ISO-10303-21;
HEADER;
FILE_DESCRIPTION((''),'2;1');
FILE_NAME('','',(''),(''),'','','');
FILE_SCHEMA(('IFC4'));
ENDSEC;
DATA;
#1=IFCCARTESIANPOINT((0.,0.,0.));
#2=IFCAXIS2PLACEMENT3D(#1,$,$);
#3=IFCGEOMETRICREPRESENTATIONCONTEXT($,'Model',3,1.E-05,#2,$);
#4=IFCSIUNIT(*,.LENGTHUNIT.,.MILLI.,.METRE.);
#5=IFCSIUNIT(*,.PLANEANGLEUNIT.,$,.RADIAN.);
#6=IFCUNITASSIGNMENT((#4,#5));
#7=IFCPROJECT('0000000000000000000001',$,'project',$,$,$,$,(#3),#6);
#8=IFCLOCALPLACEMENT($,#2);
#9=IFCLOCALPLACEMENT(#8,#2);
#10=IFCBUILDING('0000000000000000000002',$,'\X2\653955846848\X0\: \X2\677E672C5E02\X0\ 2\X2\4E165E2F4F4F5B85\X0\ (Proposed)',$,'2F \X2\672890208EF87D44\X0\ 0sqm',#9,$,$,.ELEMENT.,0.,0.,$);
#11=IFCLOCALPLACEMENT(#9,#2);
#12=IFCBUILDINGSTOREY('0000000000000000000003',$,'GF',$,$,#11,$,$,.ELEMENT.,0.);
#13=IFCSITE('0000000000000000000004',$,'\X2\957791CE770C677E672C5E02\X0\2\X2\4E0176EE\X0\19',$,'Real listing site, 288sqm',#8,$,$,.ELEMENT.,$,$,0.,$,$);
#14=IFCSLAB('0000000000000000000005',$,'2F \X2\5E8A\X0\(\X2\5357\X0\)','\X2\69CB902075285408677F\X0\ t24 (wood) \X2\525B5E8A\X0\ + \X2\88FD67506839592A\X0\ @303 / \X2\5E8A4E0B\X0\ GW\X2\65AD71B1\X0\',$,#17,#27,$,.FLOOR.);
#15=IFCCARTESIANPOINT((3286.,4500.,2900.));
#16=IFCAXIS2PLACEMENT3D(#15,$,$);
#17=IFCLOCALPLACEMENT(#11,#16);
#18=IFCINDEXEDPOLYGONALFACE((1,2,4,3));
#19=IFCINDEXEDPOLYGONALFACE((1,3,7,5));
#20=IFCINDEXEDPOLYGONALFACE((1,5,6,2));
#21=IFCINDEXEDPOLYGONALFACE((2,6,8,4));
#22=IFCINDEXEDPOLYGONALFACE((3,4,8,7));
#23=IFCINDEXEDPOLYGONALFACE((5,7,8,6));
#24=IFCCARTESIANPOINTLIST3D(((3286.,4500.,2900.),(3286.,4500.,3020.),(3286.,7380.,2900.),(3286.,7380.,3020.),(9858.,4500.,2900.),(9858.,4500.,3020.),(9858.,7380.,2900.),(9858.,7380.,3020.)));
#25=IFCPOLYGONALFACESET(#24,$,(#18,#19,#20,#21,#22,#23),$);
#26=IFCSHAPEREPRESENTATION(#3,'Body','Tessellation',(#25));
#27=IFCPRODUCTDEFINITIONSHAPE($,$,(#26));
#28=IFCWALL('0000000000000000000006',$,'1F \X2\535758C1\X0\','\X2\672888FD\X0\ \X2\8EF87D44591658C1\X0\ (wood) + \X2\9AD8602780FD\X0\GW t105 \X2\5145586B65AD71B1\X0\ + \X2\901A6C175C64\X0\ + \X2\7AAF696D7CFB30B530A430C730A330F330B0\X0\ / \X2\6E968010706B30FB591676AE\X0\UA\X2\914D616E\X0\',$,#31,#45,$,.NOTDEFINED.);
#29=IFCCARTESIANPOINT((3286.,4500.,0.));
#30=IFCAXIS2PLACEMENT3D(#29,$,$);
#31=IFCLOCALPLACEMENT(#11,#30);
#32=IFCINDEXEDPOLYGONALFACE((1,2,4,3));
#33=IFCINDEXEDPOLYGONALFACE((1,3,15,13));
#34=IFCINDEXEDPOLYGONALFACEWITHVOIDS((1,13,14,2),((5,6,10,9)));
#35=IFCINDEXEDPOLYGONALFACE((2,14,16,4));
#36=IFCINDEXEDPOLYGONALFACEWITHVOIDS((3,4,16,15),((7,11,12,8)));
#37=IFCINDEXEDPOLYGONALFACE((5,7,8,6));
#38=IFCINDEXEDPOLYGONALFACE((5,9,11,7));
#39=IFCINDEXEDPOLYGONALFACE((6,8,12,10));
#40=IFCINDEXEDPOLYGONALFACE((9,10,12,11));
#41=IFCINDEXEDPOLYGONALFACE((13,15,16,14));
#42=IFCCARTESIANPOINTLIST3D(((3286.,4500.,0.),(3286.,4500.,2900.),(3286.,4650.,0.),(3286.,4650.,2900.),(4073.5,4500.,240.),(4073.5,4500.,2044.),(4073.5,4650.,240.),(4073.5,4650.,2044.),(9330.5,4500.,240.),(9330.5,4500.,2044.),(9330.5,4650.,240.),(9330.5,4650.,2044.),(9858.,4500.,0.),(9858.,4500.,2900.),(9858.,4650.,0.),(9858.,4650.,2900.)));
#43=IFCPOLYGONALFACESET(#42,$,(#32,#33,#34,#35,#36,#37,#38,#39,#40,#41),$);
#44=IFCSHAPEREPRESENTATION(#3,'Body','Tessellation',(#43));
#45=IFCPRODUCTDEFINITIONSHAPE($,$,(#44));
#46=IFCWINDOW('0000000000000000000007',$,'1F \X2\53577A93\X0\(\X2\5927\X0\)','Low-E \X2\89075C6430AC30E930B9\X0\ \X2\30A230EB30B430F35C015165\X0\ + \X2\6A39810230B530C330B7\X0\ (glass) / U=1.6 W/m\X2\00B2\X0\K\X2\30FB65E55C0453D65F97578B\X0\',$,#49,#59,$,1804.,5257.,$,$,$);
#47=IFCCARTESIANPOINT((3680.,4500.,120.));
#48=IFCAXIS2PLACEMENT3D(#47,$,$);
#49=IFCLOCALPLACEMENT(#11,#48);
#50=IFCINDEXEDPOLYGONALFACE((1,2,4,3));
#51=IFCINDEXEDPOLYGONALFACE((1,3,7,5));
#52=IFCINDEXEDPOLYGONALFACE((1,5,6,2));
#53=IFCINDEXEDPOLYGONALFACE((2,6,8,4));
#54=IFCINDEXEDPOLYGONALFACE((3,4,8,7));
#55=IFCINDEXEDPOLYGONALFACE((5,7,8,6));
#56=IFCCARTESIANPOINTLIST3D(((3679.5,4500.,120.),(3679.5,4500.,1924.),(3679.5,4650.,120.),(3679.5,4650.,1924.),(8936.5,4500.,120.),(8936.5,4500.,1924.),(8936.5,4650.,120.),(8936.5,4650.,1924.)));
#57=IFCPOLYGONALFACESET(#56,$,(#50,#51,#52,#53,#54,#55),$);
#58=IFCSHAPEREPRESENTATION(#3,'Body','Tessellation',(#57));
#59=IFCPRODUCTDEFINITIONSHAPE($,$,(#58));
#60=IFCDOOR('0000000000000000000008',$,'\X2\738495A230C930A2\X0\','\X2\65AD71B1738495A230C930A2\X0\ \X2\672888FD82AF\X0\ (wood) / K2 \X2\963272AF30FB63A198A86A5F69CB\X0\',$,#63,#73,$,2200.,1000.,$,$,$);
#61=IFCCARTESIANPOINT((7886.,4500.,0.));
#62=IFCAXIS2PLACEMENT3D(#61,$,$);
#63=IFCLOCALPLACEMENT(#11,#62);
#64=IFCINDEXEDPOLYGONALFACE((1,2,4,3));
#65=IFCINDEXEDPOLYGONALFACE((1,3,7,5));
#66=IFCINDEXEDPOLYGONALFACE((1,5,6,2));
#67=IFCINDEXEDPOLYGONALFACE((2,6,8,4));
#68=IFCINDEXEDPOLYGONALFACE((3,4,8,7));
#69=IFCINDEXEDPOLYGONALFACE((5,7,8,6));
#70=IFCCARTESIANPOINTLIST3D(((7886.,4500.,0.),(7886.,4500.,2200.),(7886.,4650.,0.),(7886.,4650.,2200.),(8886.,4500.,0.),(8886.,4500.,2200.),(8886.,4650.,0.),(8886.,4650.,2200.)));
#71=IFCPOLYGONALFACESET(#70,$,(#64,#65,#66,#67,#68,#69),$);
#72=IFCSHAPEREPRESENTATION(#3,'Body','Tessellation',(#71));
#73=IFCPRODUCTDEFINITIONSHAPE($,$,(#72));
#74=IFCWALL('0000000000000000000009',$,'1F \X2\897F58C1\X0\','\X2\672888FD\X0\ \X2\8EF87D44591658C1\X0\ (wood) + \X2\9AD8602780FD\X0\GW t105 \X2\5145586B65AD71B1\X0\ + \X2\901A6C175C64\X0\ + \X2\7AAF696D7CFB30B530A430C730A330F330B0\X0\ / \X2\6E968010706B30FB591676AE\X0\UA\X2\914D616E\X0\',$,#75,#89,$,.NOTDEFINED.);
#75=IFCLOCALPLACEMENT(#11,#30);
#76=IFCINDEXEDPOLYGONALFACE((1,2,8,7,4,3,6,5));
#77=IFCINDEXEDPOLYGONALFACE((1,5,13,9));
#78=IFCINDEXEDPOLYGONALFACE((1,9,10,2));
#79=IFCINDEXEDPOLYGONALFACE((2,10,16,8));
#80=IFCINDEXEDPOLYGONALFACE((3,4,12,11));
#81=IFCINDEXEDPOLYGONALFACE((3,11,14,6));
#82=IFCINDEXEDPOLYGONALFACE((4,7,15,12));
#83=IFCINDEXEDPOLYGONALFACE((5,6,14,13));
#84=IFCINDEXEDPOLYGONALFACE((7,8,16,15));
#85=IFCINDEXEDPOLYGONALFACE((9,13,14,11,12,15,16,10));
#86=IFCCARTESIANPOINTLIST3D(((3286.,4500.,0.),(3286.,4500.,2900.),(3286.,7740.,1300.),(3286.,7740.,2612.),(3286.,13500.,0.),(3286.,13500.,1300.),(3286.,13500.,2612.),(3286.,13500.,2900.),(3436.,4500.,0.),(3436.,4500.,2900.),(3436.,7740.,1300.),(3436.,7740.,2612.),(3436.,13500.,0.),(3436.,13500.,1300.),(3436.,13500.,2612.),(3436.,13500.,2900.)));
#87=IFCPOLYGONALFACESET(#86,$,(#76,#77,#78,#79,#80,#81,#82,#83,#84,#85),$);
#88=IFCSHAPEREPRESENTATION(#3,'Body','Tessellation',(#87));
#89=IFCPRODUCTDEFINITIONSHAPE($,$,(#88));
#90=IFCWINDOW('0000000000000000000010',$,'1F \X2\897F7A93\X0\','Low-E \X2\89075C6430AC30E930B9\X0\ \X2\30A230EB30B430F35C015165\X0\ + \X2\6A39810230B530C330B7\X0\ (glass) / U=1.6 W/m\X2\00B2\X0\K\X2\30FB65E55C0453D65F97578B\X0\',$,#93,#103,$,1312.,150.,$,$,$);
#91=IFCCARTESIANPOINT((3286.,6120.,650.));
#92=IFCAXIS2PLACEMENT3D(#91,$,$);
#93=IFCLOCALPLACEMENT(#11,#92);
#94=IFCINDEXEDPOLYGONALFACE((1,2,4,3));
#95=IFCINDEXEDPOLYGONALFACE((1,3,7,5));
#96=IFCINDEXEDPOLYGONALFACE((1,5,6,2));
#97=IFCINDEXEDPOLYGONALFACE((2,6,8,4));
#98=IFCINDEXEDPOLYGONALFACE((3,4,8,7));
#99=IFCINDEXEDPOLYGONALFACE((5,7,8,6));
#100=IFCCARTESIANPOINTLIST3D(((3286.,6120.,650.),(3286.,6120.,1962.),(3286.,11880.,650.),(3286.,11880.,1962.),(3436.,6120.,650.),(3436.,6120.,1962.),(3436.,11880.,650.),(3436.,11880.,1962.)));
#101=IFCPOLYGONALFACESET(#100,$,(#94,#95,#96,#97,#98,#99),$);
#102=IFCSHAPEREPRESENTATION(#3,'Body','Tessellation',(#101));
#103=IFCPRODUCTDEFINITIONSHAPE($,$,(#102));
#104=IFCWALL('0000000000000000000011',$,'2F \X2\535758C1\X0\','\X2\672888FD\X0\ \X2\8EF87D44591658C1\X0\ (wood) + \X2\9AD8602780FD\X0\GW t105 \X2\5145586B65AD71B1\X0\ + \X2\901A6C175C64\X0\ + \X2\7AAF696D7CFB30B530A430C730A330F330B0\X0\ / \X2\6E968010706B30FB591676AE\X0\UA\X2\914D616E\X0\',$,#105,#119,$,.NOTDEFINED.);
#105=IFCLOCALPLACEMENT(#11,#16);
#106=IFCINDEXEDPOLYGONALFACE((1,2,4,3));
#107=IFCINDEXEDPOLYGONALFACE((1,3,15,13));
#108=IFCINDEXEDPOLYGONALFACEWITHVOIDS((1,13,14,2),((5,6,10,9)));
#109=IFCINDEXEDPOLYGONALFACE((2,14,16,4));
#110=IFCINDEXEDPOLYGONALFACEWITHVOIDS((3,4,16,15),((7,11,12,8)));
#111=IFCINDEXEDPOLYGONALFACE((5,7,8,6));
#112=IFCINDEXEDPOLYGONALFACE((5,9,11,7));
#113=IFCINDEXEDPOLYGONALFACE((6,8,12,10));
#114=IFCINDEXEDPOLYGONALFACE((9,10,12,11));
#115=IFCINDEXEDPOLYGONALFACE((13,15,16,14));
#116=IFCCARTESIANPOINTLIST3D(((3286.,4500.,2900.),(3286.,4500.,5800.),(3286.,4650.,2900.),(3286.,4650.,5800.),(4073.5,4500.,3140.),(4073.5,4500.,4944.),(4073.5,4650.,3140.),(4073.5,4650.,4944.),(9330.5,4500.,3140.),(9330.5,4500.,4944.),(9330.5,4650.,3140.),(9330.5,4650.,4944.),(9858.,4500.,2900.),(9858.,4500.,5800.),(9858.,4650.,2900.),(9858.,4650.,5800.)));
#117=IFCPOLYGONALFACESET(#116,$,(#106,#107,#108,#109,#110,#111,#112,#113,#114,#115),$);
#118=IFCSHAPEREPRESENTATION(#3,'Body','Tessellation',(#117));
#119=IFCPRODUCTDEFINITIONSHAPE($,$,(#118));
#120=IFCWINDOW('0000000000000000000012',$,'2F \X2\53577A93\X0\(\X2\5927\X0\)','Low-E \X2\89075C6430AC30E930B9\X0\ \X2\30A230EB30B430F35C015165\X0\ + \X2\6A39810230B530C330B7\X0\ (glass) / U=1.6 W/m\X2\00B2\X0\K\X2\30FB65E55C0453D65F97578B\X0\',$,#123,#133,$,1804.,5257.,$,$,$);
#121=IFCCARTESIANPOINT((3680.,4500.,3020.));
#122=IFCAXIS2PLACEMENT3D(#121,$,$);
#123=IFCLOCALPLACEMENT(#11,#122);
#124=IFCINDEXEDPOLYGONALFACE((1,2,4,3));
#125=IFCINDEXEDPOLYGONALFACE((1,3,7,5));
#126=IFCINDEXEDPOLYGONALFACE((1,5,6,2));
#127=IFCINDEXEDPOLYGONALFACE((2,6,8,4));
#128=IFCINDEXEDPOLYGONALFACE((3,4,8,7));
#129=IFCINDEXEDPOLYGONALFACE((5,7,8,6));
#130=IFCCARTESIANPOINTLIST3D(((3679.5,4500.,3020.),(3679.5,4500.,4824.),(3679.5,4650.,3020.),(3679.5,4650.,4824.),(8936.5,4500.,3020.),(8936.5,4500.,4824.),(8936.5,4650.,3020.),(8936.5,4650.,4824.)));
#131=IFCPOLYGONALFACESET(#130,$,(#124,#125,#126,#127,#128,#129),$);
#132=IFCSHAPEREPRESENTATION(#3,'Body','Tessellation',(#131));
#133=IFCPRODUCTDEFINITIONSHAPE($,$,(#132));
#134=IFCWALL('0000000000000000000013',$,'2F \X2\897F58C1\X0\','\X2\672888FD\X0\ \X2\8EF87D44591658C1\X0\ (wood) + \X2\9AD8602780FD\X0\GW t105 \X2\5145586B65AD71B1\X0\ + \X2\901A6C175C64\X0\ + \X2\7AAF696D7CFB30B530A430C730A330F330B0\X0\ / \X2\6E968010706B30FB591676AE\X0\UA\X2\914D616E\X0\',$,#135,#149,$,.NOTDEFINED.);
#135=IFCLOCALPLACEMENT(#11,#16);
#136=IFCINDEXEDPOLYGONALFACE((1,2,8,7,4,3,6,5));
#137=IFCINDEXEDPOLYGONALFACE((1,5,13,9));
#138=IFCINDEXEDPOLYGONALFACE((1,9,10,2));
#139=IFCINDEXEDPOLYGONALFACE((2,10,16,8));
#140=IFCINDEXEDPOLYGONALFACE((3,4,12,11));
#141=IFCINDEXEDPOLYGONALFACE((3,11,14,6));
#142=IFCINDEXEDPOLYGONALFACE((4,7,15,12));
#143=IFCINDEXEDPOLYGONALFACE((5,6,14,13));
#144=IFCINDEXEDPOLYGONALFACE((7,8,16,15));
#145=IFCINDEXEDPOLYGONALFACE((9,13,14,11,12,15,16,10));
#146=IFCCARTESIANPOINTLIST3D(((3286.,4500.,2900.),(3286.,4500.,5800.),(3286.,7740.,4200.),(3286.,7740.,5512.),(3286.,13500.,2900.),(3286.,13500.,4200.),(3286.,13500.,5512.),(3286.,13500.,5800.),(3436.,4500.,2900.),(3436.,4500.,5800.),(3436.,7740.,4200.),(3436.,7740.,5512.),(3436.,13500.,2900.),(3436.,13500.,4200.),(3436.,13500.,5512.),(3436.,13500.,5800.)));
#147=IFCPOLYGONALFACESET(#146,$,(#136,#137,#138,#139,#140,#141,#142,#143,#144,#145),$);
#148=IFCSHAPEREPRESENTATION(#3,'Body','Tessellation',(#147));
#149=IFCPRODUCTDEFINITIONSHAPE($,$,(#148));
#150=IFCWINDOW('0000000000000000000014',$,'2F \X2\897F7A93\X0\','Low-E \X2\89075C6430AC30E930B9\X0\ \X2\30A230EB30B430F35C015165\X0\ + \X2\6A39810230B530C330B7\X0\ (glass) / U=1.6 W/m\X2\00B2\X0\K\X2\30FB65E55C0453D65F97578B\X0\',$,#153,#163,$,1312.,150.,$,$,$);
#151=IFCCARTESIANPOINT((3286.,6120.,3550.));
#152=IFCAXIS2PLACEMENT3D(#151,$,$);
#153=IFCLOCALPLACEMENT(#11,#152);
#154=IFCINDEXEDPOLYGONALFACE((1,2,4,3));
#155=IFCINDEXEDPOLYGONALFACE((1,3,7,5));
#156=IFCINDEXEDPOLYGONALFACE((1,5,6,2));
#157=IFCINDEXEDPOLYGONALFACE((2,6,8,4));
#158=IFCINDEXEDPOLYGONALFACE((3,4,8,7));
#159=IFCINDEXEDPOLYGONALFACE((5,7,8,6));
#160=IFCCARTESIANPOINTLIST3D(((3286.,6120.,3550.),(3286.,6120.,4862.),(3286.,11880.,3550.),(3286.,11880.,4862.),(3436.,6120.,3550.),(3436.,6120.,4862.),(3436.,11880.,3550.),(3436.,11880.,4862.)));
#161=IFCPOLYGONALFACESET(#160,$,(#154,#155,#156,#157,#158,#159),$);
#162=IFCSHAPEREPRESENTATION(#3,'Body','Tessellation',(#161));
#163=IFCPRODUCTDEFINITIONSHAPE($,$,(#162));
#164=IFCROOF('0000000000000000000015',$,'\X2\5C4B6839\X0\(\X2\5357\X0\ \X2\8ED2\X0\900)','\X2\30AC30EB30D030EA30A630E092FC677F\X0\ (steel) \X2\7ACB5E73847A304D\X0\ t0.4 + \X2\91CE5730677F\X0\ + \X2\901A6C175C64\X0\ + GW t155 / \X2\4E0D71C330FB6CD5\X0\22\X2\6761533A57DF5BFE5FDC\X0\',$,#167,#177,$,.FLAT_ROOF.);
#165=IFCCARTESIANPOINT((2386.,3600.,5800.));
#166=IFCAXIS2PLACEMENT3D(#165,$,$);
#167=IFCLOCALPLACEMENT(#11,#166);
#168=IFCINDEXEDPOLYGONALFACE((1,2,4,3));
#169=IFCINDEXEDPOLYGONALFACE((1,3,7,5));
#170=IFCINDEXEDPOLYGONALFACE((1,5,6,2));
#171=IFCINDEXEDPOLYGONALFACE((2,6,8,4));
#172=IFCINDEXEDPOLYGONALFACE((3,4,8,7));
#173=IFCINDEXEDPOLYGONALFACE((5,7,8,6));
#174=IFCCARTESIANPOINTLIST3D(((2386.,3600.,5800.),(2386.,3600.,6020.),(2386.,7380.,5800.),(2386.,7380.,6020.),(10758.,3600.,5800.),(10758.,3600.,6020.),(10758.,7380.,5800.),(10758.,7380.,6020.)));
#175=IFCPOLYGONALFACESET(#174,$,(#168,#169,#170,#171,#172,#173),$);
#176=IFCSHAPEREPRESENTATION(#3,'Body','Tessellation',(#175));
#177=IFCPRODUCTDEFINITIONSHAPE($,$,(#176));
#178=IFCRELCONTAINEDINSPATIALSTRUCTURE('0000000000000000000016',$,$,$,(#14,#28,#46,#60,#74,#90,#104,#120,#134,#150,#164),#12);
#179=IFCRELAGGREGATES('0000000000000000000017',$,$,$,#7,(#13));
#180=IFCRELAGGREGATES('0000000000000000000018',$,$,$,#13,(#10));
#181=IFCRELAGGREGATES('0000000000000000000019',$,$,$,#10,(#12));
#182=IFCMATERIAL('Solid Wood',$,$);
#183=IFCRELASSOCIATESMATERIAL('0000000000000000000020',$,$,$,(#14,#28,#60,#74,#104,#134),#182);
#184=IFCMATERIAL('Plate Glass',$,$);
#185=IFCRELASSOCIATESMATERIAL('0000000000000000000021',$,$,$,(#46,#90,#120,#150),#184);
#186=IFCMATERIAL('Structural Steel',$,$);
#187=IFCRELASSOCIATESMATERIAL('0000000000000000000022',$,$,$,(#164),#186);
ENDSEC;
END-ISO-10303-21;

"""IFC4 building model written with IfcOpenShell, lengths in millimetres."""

from ifc_helpers import new_model, si_unit, frame, frame_2d, origin, place, context, project, spatial, rectangle, extrude, material, element, fill, save


model = new_model("IFC4")

# Units and contexts
model_context = context("Model", 3, precision=1e-05, world=origin())
ifc_project = project(units=[si_unit("LENGTHUNIT", "METRE", prefix="MILLI"), si_unit("PLANEANGLEUNIT", "RADIAN")], contexts=[model_context])

# Site, building, storey
site_placement = place(None, origin())
site = spatial("IfcSite", under=ifc_project, at=site_placement, Name="長野県松本市2丁目19", ObjectType="Real listing site, 288sqm", CompositionType="ELEMENT", RefElevation=0.0)
building_placement = place(site_placement, origin())
building = spatial("IfcBuilding", under=site, at=building_placement, Name="改善案: 松本市 2世帯住宅 (Proposed)", ObjectType="2F 木造軸組 0sqm", CompositionType="ELEMENT", ElevationOfRefHeight=0.0, ElevationOfTerrain=0.0)
storey_placement = place(building_placement, origin())
storey = spatial("IfcBuildingStorey", under=building, at=storey_placement, Name="GF", CompositionType="ELEMENT", Elevation=0.0)

# Slab
ifc_material_1 = material(Name="Solid Wood")
slab_1_placement = place(storey_placement, frame((3286.0, 4500.0, 2900.0)))
element("IfcSlab", 1, at=slab_1_placement, inside=storey, material=ifc_material_1, Name="2F 床(南)", Description="構造用合板 t24 (wood) 剛床 + 製材根太 @303 / 床下 GW断熱", PredefinedType="FLOOR", context=model_context, shape_type="SweptSolid", body=[
    extrude(rectangle(XDim=6572.0, YDim=2880.0, at=frame_2d((3286.0, 1440.0))), frame((3286.0, 4500.0, 2900.0)), (0.0, 0.0, 1.0), 120.0),
])

# Wall, openings, window, door
wall_1_placement = place(storey_placement, frame((3286.0, 4500.0, 0.0)))
wall_1 = element("IfcWall", 2, at=wall_1_placement, inside=storey, material=ifc_material_1, Name="1F 南壁", Description="木製 軸組外壁 (wood) + 高性能GW t105 充填断熱 + 通気層 + 窯業系サイディング / 準耐火・外皮UA配慮", PredefinedType="NOTDEFINED", context=model_context, shape_type="SweptSolid", body=[
    extrude(rectangle(XDim=6572.0, YDim=150.0, at=frame_2d((3286.0, 75.0))), frame((3286.0, 4500.0, 0.0)), (0.0, 0.0, 1.0), 2900.0),
])
opening_1_placement = place(storey_placement, frame((3680.0, 4500.0, 120.0)))
opening_1 = element("IfcOpeningElement", 3, at=opening_1_placement, cuts=wall_1, PredefinedType="NOTDEFINED", context=model_context, shape_type="SweptSolid", body=[
    extrude(rectangle(XDim=5257.0, YDim=150.0, at=frame_2d((2628.0, 75.0))), frame((3680.0, 4500.0, 120.0)), (0.0, 0.0, 1.0), 1804.0),
])
opening_2_placement = place(storey_placement, frame((7886.0, 4500.0, 0.0)))
opening_2 = element("IfcOpeningElement", 4, at=opening_2_placement, cuts=wall_1, PredefinedType="NOTDEFINED", context=model_context, shape_type="SweptSolid", body=[
    extrude(rectangle(XDim=1000.0, YDim=150.0, at=frame_2d((500.0, 75.0))), frame((7886.0, 4500.0, 0.0)), (0.0, 0.0, 1.0), 2200.0),
])
ifc_material_2 = material(Name="Plate Glass")
window_1_placement = place(storey_placement, frame((3680.0, 4500.0, 120.0)))
window_1 = element("IfcWindow", 5, at=window_1_placement, inside=storey, material=ifc_material_2, Name="1F 南窓(大)", Description="Low-E 複層ガラス アルゴン封入 + 樹脂サッシ (glass) / U=1.6 W/m²K・日射取得型", OverallHeight=1804.0, OverallWidth=5257.0, context=model_context, shape_type="SweptSolid", body=[
    extrude(rectangle(XDim=5257.0, YDim=150.0, at=frame_2d((2628.0, 75.0))), frame((3680.0, 4500.0, 120.0)), (0.0, 0.0, 1.0), 1804.0),
])
fill(opening_1, window_1)
door_placement = place(storey_placement, frame((7886.0, 4500.0, 0.0)))
door = element("IfcDoor", 6, at=door_placement, inside=storey, material=ifc_material_1, Name="玄関ドア", Description="断熱玄関ドア 木製芯 (wood) / K2 防犯・採風機構", OverallHeight=2200.0, OverallWidth=1000.0, context=model_context, shape_type="SweptSolid", body=[
    extrude(rectangle(XDim=1000.0, YDim=150.0, at=frame_2d((500.0, 75.0))), frame((7886.0, 4500.0, 0.0)), (0.0, 0.0, 1.0), 2200.0),
])
fill(opening_2, door)

# Walls, openings, windows
wall_2_placement = place(storey_placement, frame((3286.0, 4500.0, 0.0)))
wall_2 = element("IfcWall", 7, at=wall_2_placement, inside=storey, material=ifc_material_1, Name="1F 西壁", Description="木製 軸組外壁 (wood) + 高性能GW t105 充填断熱 + 通気層 + 窯業系サイディング / 準耐火・外皮UA配慮", PredefinedType="NOTDEFINED", context=model_context, shape_type="SweptSolid", body=[
    extrude(rectangle(XDim=150.0, YDim=9000.0, at=frame_2d((75.0, 4500.0))), frame((3286.0, 4500.0, 0.0)), (0.0, 0.0, 1.0), 2900.0),
])
opening_3_placement = place(storey_placement, frame((3286.0, 6120.0, 650.0)))
opening_3 = element("IfcOpeningElement", 8, at=opening_3_placement, cuts=wall_2, PredefinedType="NOTDEFINED", context=model_context, shape_type="SweptSolid", body=[
    extrude(rectangle(XDim=150.0, YDim=5760.0, at=frame_2d((75.0, 2880.0))), frame((3286.0, 6120.0, 650.0)), (0.0, 0.0, 1.0), 1312.0),
])
window_2_placement = place(storey_placement, frame((3286.0, 6120.0, 650.0)))
window_2 = element("IfcWindow", 9, at=window_2_placement, inside=storey, material=ifc_material_2, Name="1F 西窓", Description="Low-E 複層ガラス アルゴン封入 + 樹脂サッシ (glass) / U=1.6 W/m²K・日射取得型", OverallHeight=1312.0, OverallWidth=150.0, context=model_context, shape_type="SweptSolid", body=[
    extrude(rectangle(XDim=150.0, YDim=5760.0, at=frame_2d((75.0, 2880.0))), frame((3286.0, 6120.0, 650.0)), (0.0, 0.0, 1.0), 1312.0),
])
fill(opening_3, window_2)
wall_3_placement = place(storey_placement, frame((3286.0, 4500.0, 2900.0)))
wall_3 = element("IfcWall", 10, at=wall_3_placement, inside=storey, material=ifc_material_1, Name="2F 南壁", Description="木製 軸組外壁 (wood) + 高性能GW t105 充填断熱 + 通気層 + 窯業系サイディング / 準耐火・外皮UA配慮", PredefinedType="NOTDEFINED", context=model_context, shape_type="SweptSolid", body=[
    extrude(rectangle(XDim=6572.0, YDim=150.0, at=frame_2d((3286.0, 75.0))), frame((3286.0, 4500.0, 2900.0)), (0.0, 0.0, 1.0), 2900.0),
])
opening_4_placement = place(storey_placement, frame((3680.0, 4500.0, 3020.0)))
opening_4 = element("IfcOpeningElement", 11, at=opening_4_placement, cuts=wall_3, PredefinedType="NOTDEFINED", context=model_context, shape_type="SweptSolid", body=[
    extrude(rectangle(XDim=5257.0, YDim=150.0, at=frame_2d((2628.0, 75.0))), frame((3680.0, 4500.0, 3020.0)), (0.0, 0.0, 1.0), 1804.0),
])
window_3_placement = place(storey_placement, frame((3680.0, 4500.0, 3020.0)))
window_3 = element("IfcWindow", 12, at=window_3_placement, inside=storey, material=ifc_material_2, Name="2F 南窓(大)", Description="Low-E 複層ガラス アルゴン封入 + 樹脂サッシ (glass) / U=1.6 W/m²K・日射取得型", OverallHeight=1804.0, OverallWidth=5257.0, context=model_context, shape_type="SweptSolid", body=[
    extrude(rectangle(XDim=5257.0, YDim=150.0, at=frame_2d((2628.0, 75.0))), frame((3680.0, 4500.0, 3020.0)), (0.0, 0.0, 1.0), 1804.0),
])
fill(opening_4, window_3)
wall_4_placement = place(storey_placement, frame((3286.0, 4500.0, 2900.0)))
wall_4 = element("IfcWall", 13, at=wall_4_placement, inside=storey, material=ifc_material_1, Name="2F 西壁", Description="木製 軸組外壁 (wood) + 高性能GW t105 充填断熱 + 通気層 + 窯業系サイディング / 準耐火・外皮UA配慮", PredefinedType="NOTDEFINED", context=model_context, shape_type="SweptSolid", body=[
    extrude(rectangle(XDim=150.0, YDim=9000.0, at=frame_2d((75.0, 4500.0))), frame((3286.0, 4500.0, 2900.0)), (0.0, 0.0, 1.0), 2900.0),
])
opening_5_placement = place(storey_placement, frame((3286.0, 6120.0, 3550.0)))
opening_5 = element("IfcOpeningElement", 14, at=opening_5_placement, cuts=wall_4, PredefinedType="NOTDEFINED", context=model_context, shape_type="SweptSolid", body=[
    extrude(rectangle(XDim=150.0, YDim=5760.0, at=frame_2d((75.0, 2880.0))), frame((3286.0, 6120.0, 3550.0)), (0.0, 0.0, 1.0), 1312.0),
])
window_4_placement = place(storey_placement, frame((3286.0, 6120.0, 3550.0)))
window_4 = element("IfcWindow", 15, at=window_4_placement, inside=storey, material=ifc_material_2, Name="2F 西窓", Description="Low-E 複層ガラス アルゴン封入 + 樹脂サッシ (glass) / U=1.6 W/m²K・日射取得型", OverallHeight=1312.0, OverallWidth=150.0, context=model_context, shape_type="SweptSolid", body=[
    extrude(rectangle(XDim=150.0, YDim=5760.0, at=frame_2d((75.0, 2880.0))), frame((3286.0, 6120.0, 3550.0)), (0.0, 0.0, 1.0), 1312.0),
])
fill(opening_5, window_4)

# Roof
ifc_material_3 = material(Name="Structural Steel")
roof_1_placement = place(storey_placement, frame((2386.0, 3600.0, 5800.0)))
element("IfcRoof", 16, at=roof_1_placement, inside=storey, material=ifc_material_3, Name="屋根(南 軒900)", Description="ガルバリウム鋼板 (steel) 立平葺き t0.4 + 野地板 + 通気層 + GW t155 / 不燃・法22条区域対応", PredefinedType="FLAT_ROOF", context=model_context, shape_type="SweptSolid", body=[
    extrude(rectangle(XDim=8372.0, YDim=3780.0, at=frame_2d((4186.0, 1890.0))), frame((2386.0, 3600.0, 5800.0)), (0.0, 0.0, 1.0), 220.0),
])

save(model, "model.ifc")
